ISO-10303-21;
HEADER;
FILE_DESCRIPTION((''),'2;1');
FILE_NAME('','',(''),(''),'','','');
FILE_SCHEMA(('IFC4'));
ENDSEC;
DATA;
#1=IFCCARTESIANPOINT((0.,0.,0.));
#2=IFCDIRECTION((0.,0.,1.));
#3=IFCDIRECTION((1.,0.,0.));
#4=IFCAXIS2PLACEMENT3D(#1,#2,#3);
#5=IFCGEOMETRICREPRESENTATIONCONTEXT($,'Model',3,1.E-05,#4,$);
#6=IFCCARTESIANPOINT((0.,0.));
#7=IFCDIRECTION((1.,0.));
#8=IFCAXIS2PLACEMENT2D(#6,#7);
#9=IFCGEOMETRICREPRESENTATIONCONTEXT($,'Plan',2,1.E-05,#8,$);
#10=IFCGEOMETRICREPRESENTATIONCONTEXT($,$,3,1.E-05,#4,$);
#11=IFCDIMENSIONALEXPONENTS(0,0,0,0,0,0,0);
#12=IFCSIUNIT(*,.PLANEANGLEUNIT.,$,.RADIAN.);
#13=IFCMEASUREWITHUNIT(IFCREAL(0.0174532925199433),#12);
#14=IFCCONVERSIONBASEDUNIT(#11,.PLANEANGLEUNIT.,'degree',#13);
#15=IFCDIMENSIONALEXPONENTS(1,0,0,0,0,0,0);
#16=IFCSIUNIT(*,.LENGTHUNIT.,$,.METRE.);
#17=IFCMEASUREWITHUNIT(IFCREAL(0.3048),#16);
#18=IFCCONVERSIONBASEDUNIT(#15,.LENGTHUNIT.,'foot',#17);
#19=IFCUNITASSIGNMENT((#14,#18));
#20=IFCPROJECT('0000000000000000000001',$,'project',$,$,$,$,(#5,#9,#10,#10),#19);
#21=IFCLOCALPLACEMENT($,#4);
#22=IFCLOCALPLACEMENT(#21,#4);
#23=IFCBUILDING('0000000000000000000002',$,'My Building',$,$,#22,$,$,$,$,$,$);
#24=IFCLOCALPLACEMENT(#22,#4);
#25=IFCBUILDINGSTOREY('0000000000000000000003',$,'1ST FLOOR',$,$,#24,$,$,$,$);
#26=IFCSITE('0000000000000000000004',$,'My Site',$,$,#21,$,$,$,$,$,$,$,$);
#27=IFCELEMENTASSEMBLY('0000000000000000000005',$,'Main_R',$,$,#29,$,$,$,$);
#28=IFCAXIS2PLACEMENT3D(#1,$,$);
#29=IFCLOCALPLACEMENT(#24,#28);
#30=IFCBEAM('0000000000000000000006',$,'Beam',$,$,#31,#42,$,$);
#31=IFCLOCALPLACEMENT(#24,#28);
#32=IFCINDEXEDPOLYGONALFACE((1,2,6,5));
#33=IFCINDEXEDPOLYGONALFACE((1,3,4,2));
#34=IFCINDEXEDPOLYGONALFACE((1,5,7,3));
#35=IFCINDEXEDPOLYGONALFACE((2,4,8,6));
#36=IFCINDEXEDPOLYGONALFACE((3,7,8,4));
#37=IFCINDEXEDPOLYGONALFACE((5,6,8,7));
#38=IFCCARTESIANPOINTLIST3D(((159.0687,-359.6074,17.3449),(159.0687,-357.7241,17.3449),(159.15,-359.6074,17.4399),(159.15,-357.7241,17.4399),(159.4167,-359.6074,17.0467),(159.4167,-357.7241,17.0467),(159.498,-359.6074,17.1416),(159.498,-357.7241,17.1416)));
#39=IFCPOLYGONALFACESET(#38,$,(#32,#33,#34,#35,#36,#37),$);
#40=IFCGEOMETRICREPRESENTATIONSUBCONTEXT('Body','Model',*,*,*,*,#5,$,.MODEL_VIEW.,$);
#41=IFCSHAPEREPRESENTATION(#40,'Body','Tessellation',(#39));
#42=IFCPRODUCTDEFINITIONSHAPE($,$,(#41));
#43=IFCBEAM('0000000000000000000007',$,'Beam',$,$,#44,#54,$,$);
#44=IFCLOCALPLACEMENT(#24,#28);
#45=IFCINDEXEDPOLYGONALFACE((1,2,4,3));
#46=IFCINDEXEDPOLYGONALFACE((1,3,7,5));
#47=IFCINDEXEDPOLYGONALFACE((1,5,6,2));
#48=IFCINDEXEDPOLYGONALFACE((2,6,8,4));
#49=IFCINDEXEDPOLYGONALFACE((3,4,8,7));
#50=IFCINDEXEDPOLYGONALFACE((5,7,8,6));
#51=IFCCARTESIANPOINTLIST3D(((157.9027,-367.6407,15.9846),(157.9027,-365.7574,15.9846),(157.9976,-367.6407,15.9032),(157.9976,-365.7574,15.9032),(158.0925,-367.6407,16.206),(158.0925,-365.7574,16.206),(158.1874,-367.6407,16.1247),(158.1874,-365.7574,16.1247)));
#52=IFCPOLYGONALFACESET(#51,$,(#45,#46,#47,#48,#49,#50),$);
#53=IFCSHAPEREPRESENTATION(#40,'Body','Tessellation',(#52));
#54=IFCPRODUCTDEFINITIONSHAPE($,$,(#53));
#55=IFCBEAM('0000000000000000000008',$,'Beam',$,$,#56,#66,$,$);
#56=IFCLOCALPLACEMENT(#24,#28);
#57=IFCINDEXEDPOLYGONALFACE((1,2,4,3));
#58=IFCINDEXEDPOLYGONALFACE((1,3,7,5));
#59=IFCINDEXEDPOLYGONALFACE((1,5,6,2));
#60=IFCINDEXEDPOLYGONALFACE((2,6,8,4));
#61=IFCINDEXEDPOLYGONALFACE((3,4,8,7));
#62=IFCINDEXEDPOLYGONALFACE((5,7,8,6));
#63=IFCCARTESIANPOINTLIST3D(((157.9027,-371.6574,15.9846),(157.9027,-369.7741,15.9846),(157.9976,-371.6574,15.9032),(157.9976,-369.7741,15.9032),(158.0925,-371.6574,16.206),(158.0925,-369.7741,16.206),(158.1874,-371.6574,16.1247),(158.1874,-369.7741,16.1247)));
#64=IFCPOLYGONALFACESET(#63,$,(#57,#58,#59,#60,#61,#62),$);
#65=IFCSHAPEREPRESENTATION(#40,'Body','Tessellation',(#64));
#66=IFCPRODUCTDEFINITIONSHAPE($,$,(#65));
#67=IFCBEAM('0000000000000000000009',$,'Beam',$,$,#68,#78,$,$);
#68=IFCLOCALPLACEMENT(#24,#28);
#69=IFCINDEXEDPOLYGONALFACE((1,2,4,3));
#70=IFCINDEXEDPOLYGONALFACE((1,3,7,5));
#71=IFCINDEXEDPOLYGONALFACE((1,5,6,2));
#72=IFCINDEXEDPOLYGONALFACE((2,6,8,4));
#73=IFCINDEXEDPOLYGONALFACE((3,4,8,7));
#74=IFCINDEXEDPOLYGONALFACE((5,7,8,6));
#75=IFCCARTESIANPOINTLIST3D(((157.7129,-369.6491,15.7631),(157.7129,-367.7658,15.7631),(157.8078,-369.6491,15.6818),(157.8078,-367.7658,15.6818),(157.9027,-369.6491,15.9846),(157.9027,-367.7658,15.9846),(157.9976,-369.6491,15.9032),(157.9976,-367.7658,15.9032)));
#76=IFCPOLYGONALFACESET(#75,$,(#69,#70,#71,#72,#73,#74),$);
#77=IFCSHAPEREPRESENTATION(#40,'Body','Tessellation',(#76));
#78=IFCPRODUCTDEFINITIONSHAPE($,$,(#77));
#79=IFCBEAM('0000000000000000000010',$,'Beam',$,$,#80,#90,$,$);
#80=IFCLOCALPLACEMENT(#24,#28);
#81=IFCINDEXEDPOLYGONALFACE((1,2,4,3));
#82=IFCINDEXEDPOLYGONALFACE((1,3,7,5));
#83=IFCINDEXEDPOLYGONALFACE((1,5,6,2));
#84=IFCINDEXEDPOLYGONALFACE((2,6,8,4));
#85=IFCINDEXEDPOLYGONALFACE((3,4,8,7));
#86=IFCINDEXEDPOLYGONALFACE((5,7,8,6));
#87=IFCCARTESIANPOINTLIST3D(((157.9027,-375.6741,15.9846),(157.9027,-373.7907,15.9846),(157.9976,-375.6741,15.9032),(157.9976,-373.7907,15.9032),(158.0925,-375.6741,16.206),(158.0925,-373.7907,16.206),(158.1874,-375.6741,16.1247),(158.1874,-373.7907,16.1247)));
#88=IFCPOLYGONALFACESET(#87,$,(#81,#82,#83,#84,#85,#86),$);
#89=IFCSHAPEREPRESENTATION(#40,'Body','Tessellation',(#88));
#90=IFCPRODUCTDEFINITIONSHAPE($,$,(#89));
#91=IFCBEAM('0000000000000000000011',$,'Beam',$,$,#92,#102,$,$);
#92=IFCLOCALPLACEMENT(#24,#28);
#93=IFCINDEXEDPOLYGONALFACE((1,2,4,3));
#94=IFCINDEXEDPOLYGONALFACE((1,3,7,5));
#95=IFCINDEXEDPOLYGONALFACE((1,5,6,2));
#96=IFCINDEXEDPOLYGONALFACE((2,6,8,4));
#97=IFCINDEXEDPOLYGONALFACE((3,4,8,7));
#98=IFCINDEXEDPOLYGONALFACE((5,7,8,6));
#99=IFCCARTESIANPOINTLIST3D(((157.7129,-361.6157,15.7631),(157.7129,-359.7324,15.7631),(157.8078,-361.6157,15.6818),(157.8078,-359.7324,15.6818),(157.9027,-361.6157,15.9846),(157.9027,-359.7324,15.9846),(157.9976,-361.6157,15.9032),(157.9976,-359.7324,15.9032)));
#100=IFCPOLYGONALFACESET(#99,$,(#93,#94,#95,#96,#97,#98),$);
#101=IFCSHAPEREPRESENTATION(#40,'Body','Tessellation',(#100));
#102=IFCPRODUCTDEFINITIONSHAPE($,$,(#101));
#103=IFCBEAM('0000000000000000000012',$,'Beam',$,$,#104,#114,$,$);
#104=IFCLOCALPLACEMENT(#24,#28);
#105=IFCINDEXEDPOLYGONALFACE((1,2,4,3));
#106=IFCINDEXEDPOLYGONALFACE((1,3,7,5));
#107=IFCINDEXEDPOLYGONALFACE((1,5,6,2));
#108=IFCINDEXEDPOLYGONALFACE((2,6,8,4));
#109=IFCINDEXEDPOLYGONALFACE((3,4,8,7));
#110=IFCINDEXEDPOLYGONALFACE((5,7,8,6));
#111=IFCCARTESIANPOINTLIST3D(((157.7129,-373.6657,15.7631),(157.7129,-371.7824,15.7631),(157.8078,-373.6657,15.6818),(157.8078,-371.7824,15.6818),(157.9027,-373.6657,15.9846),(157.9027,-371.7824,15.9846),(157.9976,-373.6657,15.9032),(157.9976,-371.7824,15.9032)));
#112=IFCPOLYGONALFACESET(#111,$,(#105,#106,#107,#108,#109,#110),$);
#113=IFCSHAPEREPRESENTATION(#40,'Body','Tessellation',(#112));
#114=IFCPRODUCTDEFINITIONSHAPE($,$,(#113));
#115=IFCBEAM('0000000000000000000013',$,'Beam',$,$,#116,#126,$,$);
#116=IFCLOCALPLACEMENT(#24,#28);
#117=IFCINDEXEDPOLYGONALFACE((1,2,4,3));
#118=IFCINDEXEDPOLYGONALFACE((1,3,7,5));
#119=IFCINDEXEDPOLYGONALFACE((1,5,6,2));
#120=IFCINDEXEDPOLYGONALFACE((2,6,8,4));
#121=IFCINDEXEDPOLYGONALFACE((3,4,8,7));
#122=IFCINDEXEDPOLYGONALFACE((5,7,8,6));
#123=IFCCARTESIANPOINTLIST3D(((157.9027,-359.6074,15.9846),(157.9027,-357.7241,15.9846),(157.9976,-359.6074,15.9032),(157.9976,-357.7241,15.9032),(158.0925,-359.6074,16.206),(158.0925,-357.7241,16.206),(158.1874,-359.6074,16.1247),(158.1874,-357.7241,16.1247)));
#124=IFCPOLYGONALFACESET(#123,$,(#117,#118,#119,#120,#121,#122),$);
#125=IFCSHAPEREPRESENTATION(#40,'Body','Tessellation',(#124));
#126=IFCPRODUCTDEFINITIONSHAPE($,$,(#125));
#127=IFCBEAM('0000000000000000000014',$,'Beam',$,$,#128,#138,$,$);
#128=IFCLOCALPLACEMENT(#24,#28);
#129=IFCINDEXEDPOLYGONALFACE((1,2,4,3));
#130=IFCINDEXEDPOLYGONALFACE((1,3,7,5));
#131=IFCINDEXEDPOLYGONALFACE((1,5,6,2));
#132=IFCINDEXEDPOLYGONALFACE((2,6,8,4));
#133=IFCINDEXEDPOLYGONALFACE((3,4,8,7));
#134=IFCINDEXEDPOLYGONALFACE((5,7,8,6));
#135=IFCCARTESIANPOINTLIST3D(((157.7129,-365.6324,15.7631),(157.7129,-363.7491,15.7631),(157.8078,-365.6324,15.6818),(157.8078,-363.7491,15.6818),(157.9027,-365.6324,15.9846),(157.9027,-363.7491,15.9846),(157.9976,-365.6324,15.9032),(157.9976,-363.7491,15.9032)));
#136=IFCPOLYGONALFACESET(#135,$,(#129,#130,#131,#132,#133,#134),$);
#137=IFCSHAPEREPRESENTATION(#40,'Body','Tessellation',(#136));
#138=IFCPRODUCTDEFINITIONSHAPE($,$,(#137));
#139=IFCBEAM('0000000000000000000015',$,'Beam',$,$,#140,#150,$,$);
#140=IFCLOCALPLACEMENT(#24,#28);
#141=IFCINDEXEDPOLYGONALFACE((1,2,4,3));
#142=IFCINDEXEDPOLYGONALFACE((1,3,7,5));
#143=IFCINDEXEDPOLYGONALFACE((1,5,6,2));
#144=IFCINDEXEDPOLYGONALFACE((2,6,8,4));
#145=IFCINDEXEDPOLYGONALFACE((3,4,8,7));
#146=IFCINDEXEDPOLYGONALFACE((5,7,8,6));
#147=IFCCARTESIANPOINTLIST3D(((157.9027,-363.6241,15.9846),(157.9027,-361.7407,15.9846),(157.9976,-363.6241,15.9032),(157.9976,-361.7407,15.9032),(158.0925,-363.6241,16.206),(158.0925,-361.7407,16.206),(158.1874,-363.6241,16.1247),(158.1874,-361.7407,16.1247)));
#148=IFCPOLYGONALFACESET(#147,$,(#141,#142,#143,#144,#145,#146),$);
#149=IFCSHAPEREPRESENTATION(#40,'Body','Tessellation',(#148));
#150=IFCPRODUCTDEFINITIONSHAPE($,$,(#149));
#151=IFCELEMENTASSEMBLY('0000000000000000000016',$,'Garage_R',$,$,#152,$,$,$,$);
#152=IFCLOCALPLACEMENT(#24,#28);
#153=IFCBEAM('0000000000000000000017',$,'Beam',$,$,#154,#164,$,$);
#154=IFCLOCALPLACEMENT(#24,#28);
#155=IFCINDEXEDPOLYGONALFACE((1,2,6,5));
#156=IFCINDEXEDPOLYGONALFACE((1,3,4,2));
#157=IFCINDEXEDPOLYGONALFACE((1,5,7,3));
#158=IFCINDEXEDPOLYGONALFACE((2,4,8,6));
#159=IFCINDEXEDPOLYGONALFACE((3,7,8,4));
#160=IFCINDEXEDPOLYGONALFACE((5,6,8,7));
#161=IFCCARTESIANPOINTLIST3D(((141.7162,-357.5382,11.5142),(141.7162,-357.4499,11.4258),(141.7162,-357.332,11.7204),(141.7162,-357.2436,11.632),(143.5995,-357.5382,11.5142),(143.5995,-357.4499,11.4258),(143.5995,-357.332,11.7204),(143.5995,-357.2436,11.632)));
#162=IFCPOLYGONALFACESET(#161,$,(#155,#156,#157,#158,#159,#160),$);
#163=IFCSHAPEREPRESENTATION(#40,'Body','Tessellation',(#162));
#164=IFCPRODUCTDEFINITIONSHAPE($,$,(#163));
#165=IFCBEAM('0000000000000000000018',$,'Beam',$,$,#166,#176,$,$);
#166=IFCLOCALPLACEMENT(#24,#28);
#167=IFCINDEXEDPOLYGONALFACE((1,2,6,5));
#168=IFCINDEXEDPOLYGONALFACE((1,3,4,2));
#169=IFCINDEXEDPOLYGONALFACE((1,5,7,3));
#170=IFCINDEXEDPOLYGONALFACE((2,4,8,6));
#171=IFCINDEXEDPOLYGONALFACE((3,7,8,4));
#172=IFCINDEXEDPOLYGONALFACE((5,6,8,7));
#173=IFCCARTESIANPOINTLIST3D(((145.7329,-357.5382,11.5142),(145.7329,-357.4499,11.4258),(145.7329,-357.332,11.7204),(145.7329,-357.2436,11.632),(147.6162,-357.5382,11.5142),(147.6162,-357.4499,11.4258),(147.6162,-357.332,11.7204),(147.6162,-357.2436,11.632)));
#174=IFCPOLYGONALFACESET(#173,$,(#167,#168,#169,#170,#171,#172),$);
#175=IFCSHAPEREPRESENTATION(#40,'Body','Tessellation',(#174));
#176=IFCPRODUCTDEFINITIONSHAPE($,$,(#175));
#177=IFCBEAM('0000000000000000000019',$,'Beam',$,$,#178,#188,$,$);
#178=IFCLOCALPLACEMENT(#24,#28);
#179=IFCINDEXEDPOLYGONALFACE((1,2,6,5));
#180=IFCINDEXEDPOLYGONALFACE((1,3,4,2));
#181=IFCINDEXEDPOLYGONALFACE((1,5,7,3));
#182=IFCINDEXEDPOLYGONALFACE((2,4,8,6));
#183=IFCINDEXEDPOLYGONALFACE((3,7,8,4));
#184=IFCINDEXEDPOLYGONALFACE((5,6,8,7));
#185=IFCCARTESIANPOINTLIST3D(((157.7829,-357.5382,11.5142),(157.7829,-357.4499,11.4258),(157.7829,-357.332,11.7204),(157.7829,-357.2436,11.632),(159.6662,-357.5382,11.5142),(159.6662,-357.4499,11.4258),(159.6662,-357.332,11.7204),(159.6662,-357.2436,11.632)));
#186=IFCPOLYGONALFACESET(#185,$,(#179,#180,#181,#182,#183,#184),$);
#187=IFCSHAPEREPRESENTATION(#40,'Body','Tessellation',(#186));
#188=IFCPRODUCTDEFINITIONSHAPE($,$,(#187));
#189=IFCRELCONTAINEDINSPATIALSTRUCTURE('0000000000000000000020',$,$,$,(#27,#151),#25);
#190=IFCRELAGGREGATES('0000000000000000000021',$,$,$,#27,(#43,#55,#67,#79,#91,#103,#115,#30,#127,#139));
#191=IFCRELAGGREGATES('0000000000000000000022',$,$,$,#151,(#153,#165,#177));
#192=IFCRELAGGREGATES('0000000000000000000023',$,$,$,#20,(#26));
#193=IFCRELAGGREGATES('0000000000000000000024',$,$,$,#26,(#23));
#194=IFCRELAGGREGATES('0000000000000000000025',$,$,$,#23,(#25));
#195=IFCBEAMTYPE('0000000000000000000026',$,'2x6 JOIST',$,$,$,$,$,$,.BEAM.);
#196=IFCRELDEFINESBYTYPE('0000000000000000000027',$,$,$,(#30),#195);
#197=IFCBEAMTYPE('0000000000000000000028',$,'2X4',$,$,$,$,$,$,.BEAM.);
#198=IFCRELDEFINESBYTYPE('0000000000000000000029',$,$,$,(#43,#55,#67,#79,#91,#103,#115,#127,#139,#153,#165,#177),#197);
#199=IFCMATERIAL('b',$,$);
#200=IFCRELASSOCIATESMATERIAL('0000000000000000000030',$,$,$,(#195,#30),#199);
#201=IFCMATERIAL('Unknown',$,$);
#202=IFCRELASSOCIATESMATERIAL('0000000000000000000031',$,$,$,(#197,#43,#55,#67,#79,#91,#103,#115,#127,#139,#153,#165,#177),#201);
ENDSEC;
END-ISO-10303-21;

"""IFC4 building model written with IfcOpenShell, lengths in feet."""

from ifc_helpers import new_model, entity, si_unit, converted_unit, frame, origin_with_axes, origin_2d_with_axis, place, context, subcontext, project, spatial, rectangle, extrude, material, material_profile, profile_set, profile_usage, type_object, element, aggregate, save


model = new_model("IFC4")

# Units and contexts
model_context = context("Model", 3, precision=1e-05, world=origin_with_axes())
plan_context = context("Plan", 2, precision=1e-05, world=origin_2d_with_axis())
context_of_model = context(None, 3, precision=1e-05, world=origin_with_axes())
body_context = subcontext(model_context, "Body", "Model", "MODEL_VIEW")
ifc_project = project(units=[converted_unit("PLANEANGLEUNIT", "degree", entity("IfcReal", 0.0174532925199433), si_unit("PLANEANGLEUNIT", "RADIAN"), dimensions=[0, 0, 0, 0, 0, 0, 0]), converted_unit("LENGTHUNIT", "foot", entity("IfcReal", 0.3048), si_unit("LENGTHUNIT", "METRE"), dimensions=[1, 0, 0, 0, 0, 0, 0])], contexts=[model_context, plan_context, context_of_model, context_of_model])

# Site, building, storey
site_placement = place(None, origin_with_axes())
site = spatial("IfcSite", under=ifc_project, at=site_placement, Name="My Site")
building_placement = place(site_placement, origin_with_axes())
building = spatial("IfcBuilding", under=site, at=building_placement, Name="My Building")
storey_placement = place(building_placement, origin_with_axes())
storey = spatial("IfcBuildingStorey", under=building, at=storey_placement, Name="1ST FLOOR")

# Element assemblies, beams
assembly_1_placement = place(storey_placement, origin_with_axes())
assembly_1 = element("IfcElementAssembly", 1, at=assembly_1_placement, inside=storey, Name="Main_R")
ifc_material_1 = material(Name="b")
ifc_material_profile_1 = material_profile(ifc_material_1, rectangle(XDim=0.125, YDim=0.4583))
ifc_profile_set_1 = profile_set([ifc_material_profile_1])
ifc_profile_usage_1 = profile_usage(ifc_profile_set_1, cardinal=8)
beam_type_1 = type_object("IfcBeamType", Name="2x6 JOIST", PredefinedType="BEAM", material=ifc_profile_set_1)
beam_1_placement = place(assembly_1_placement, frame((159.1094, -357.7241, 17.3924), z_axis=(0.0, -1.0, 0.0), x_axis=(0.650774, 0.0, 0.759271)))
beam_1 = element("IfcBeam", 2, at=beam_1_placement, type_object=beam_type_1, material=ifc_profile_usage_1, Name="Beam", context=body_context, shape_type="SweptSolid", body=[
    extrude(rectangle(XDim=0.125, YDim=0.4583), frame((0.0, -0.2291, 0.0)), (0.0, 0.0, 1.0), 1.8833),
])
ifc_material_2 = material(Name="Unknown")
ifc_material_profile_2 = material_profile(ifc_material_2, rectangle(XDim=0.125, YDim=0.2917))
ifc_profile_set_2 = profile_set([ifc_material_profile_2])
ifc_profile_usage_2 = profile_usage(ifc_profile_set_2, cardinal=5)
beam_type_2 = type_object("IfcBeamType", Name="2X4", PredefinedType="BEAM", material=ifc_profile_set_2)
beam_2_placement = place(assembly_1_placement, frame((158.0451, -365.7574, 16.0546), z_axis=(0.0, -1.0, 0.0), x_axis=(-0.759271, 0.0, 0.650774)))
beam_2 = element("IfcBeam", 3, at=beam_2_placement, type_object=beam_type_2, material=ifc_profile_usage_2, Name="Beam", context=body_context, shape_type="SweptSolid", body=[
    extrude(rectangle(XDim=0.125, YDim=0.2917), origin_with_axes(), (0.0, 0.0, 1.0), 1.8833),
])
ifc_profile_usage_3 = profile_usage(ifc_profile_set_2, cardinal=5)
beam_3_placement = place(assembly_1_placement, frame((158.0451, -369.7741, 16.0546), z_axis=(0.0, -1.0, 0.0), x_axis=(-0.759271, 0.0, 0.650774)))
beam_3 = element("IfcBeam", 4, at=beam_3_placement, type_object=beam_type_2, material=ifc_profile_usage_3, Name="Beam", context=body_context, shape_type="SweptSolid", body=[
    extrude(rectangle(XDim=0.125, YDim=0.2917), origin_with_axes(), (0.0, 0.0, 1.0), 1.8833),
])
ifc_profile_usage_4 = profile_usage(ifc_profile_set_2, cardinal=5)
beam_4_placement = place(assembly_1_placement, frame((157.8553, -367.7658, 15.8332), z_axis=(0.0, -1.0, 0.0), x_axis=(-0.759271, 0.0, 0.650774)))
beam_4 = element("IfcBeam", 5, at=beam_4_placement, type_object=beam_type_2, material=ifc_profile_usage_4, Name="Beam", context=body_context, shape_type="SweptSolid", body=[
    extrude(rectangle(XDim=0.125, YDim=0.2917), origin_with_axes(), (0.0, 0.0, 1.0), 1.8833),
])
ifc_profile_usage_5 = profile_usage(ifc_profile_set_2, cardinal=5)
beam_5_placement = place(assembly_1_placement, frame((158.0451, -373.7907, 16.0546), z_axis=(0.0, -1.0, 0.0), x_axis=(-0.759271, 0.0, 0.650774)))
beam_5 = element("IfcBeam", 6, at=beam_5_placement, type_object=beam_type_2, material=ifc_profile_usage_5, Name="Beam", context=body_context, shape_type="SweptSolid", body=[
    extrude(rectangle(XDim=0.125, YDim=0.2917), origin_with_axes(), (0.0, 0.0, 1.0), 1.8833),
])
ifc_profile_usage_6 = profile_usage(ifc_profile_set_2, cardinal=5)
beam_6_placement = place(assembly_1_placement, frame((157.8553, -359.7324, 15.8332), z_axis=(0.0, -1.0, 0.0), x_axis=(-0.759271, 0.0, 0.650774)))
beam_6 = element("IfcBeam", 7, at=beam_6_placement, type_object=beam_type_2, material=ifc_profile_usage_6, Name="Beam", context=body_context, shape_type="SweptSolid", body=[
    extrude(rectangle(XDim=0.125, YDim=0.2917), origin_with_axes(), (0.0, 0.0, 1.0), 1.8833),
])
ifc_profile_usage_7 = profile_usage(ifc_profile_set_2, cardinal=5)
beam_7_placement = place(assembly_1_placement, frame((157.8553, -371.7824, 15.8332), z_axis=(0.0, -1.0, 0.0), x_axis=(-0.759271, 0.0, 0.650774)))
beam_7 = element("IfcBeam", 8, at=beam_7_placement, type_object=beam_type_2, material=ifc_profile_usage_7, Name="Beam", context=body_context, shape_type="SweptSolid", body=[
    extrude(rectangle(XDim=0.125, YDim=0.2917), origin_with_axes(), (0.0, 0.0, 1.0), 1.8833),
])
ifc_profile_usage_8 = profile_usage(ifc_profile_set_2, cardinal=5)
beam_8_placement = place(assembly_1_placement, frame((158.0451, -357.7241, 16.0546), z_axis=(0.0, -1.0, 0.0), x_axis=(-0.759271, 0.0, 0.650774)))
beam_8 = element("IfcBeam", 9, at=beam_8_placement, type_object=beam_type_2, material=ifc_profile_usage_8, Name="Beam", context=body_context, shape_type="SweptSolid", body=[
    extrude(rectangle(XDim=0.125, YDim=0.2917), origin_with_axes(), (0.0, 0.0, 1.0), 1.8833),
])
ifc_profile_usage_9 = profile_usage(ifc_profile_set_2, cardinal=5)
beam_9_placement = place(assembly_1_placement, frame((157.8553, -363.7491, 15.8332), z_axis=(0.0, -1.0, 0.0), x_axis=(-0.759271, 0.0, 0.650774)))
beam_9 = element("IfcBeam", 10, at=beam_9_placement, type_object=beam_type_2, material=ifc_profile_usage_9, Name="Beam", context=body_context, shape_type="SweptSolid", body=[
    extrude(rectangle(XDim=0.125, YDim=0.2917), origin_with_axes(), (0.0, 0.0, 1.0), 1.8833),
])
ifc_profile_usage_10 = profile_usage(ifc_profile_set_2, cardinal=5)
beam_10_placement = place(assembly_1_placement, frame((158.0451, -361.7407, 16.0546), z_axis=(0.0, -1.0, 0.0), x_axis=(-0.759271, 0.0, 0.650774)))
beam_10 = element("IfcBeam", 11, at=beam_10_placement, type_object=beam_type_2, material=ifc_profile_usage_10, Name="Beam", context=body_context, shape_type="SweptSolid", body=[
    extrude(rectangle(XDim=0.125, YDim=0.2917), origin_with_axes(), (0.0, 0.0, 1.0), 1.8833),
])
aggregate(assembly_1, [beam_2, beam_3, beam_4, beam_5, beam_6, beam_7, beam_8, beam_1, beam_9, beam_10])
assembly_2_placement = place(storey_placement, origin_with_axes())
assembly_2 = element("IfcElementAssembly", 12, at=assembly_2_placement, inside=storey, Name="Garage_R")
ifc_profile_usage_11 = profile_usage(ifc_profile_set_2, cardinal=5)
beam_11_placement = place(assembly_2_placement, frame((141.7162, -357.3909, 11.5731), z_axis=(1.0, -0.000001, 0.0), x_axis=(0.0, -0.707107, 0.707107)))
beam_11 = element("IfcBeam", 13, at=beam_11_placement, type_object=beam_type_2, material=ifc_profile_usage_11, Name="Beam", context=body_context, shape_type="SweptSolid", body=[
    extrude(rectangle(XDim=0.125, YDim=0.2917), origin_with_axes(), (0.0, 0.0, 1.0), 1.8833),
])
ifc_profile_usage_12 = profile_usage(ifc_profile_set_2, cardinal=5)
beam_12_placement = place(assembly_2_placement, frame((145.7329, -357.3909, 11.5731), z_axis=(1.0, -0.000001, 0.0), x_axis=(0.0, -0.707107, 0.707107)))
beam_12 = element("IfcBeam", 14, at=beam_12_placement, type_object=beam_type_2, material=ifc_profile_usage_12, Name="Beam", context=body_context, shape_type="SweptSolid", body=[
    extrude(rectangle(XDim=0.125, YDim=0.2917), origin_with_axes(), (0.0, 0.0, 1.0), 1.8833),
])
ifc_profile_usage_13 = profile_usage(ifc_profile_set_2, cardinal=5)
beam_13_placement = place(assembly_2_placement, frame((157.7829, -357.3909, 11.5731), z_axis=(1.0, -0.000001, 0.0), x_axis=(0.0, -0.707107, 0.707107)))
beam_13 = element("IfcBeam", 15, at=beam_13_placement, type_object=beam_type_2, material=ifc_profile_usage_13, Name="Beam", context=body_context, shape_type="SweptSolid", body=[
    extrude(rectangle(XDim=0.125, YDim=0.2917), origin_with_axes(), (0.0, 0.0, 1.0), 1.8833),
])
aggregate(assembly_2, [beam_11, beam_12, beam_13])

save(model, "model.ifc")
